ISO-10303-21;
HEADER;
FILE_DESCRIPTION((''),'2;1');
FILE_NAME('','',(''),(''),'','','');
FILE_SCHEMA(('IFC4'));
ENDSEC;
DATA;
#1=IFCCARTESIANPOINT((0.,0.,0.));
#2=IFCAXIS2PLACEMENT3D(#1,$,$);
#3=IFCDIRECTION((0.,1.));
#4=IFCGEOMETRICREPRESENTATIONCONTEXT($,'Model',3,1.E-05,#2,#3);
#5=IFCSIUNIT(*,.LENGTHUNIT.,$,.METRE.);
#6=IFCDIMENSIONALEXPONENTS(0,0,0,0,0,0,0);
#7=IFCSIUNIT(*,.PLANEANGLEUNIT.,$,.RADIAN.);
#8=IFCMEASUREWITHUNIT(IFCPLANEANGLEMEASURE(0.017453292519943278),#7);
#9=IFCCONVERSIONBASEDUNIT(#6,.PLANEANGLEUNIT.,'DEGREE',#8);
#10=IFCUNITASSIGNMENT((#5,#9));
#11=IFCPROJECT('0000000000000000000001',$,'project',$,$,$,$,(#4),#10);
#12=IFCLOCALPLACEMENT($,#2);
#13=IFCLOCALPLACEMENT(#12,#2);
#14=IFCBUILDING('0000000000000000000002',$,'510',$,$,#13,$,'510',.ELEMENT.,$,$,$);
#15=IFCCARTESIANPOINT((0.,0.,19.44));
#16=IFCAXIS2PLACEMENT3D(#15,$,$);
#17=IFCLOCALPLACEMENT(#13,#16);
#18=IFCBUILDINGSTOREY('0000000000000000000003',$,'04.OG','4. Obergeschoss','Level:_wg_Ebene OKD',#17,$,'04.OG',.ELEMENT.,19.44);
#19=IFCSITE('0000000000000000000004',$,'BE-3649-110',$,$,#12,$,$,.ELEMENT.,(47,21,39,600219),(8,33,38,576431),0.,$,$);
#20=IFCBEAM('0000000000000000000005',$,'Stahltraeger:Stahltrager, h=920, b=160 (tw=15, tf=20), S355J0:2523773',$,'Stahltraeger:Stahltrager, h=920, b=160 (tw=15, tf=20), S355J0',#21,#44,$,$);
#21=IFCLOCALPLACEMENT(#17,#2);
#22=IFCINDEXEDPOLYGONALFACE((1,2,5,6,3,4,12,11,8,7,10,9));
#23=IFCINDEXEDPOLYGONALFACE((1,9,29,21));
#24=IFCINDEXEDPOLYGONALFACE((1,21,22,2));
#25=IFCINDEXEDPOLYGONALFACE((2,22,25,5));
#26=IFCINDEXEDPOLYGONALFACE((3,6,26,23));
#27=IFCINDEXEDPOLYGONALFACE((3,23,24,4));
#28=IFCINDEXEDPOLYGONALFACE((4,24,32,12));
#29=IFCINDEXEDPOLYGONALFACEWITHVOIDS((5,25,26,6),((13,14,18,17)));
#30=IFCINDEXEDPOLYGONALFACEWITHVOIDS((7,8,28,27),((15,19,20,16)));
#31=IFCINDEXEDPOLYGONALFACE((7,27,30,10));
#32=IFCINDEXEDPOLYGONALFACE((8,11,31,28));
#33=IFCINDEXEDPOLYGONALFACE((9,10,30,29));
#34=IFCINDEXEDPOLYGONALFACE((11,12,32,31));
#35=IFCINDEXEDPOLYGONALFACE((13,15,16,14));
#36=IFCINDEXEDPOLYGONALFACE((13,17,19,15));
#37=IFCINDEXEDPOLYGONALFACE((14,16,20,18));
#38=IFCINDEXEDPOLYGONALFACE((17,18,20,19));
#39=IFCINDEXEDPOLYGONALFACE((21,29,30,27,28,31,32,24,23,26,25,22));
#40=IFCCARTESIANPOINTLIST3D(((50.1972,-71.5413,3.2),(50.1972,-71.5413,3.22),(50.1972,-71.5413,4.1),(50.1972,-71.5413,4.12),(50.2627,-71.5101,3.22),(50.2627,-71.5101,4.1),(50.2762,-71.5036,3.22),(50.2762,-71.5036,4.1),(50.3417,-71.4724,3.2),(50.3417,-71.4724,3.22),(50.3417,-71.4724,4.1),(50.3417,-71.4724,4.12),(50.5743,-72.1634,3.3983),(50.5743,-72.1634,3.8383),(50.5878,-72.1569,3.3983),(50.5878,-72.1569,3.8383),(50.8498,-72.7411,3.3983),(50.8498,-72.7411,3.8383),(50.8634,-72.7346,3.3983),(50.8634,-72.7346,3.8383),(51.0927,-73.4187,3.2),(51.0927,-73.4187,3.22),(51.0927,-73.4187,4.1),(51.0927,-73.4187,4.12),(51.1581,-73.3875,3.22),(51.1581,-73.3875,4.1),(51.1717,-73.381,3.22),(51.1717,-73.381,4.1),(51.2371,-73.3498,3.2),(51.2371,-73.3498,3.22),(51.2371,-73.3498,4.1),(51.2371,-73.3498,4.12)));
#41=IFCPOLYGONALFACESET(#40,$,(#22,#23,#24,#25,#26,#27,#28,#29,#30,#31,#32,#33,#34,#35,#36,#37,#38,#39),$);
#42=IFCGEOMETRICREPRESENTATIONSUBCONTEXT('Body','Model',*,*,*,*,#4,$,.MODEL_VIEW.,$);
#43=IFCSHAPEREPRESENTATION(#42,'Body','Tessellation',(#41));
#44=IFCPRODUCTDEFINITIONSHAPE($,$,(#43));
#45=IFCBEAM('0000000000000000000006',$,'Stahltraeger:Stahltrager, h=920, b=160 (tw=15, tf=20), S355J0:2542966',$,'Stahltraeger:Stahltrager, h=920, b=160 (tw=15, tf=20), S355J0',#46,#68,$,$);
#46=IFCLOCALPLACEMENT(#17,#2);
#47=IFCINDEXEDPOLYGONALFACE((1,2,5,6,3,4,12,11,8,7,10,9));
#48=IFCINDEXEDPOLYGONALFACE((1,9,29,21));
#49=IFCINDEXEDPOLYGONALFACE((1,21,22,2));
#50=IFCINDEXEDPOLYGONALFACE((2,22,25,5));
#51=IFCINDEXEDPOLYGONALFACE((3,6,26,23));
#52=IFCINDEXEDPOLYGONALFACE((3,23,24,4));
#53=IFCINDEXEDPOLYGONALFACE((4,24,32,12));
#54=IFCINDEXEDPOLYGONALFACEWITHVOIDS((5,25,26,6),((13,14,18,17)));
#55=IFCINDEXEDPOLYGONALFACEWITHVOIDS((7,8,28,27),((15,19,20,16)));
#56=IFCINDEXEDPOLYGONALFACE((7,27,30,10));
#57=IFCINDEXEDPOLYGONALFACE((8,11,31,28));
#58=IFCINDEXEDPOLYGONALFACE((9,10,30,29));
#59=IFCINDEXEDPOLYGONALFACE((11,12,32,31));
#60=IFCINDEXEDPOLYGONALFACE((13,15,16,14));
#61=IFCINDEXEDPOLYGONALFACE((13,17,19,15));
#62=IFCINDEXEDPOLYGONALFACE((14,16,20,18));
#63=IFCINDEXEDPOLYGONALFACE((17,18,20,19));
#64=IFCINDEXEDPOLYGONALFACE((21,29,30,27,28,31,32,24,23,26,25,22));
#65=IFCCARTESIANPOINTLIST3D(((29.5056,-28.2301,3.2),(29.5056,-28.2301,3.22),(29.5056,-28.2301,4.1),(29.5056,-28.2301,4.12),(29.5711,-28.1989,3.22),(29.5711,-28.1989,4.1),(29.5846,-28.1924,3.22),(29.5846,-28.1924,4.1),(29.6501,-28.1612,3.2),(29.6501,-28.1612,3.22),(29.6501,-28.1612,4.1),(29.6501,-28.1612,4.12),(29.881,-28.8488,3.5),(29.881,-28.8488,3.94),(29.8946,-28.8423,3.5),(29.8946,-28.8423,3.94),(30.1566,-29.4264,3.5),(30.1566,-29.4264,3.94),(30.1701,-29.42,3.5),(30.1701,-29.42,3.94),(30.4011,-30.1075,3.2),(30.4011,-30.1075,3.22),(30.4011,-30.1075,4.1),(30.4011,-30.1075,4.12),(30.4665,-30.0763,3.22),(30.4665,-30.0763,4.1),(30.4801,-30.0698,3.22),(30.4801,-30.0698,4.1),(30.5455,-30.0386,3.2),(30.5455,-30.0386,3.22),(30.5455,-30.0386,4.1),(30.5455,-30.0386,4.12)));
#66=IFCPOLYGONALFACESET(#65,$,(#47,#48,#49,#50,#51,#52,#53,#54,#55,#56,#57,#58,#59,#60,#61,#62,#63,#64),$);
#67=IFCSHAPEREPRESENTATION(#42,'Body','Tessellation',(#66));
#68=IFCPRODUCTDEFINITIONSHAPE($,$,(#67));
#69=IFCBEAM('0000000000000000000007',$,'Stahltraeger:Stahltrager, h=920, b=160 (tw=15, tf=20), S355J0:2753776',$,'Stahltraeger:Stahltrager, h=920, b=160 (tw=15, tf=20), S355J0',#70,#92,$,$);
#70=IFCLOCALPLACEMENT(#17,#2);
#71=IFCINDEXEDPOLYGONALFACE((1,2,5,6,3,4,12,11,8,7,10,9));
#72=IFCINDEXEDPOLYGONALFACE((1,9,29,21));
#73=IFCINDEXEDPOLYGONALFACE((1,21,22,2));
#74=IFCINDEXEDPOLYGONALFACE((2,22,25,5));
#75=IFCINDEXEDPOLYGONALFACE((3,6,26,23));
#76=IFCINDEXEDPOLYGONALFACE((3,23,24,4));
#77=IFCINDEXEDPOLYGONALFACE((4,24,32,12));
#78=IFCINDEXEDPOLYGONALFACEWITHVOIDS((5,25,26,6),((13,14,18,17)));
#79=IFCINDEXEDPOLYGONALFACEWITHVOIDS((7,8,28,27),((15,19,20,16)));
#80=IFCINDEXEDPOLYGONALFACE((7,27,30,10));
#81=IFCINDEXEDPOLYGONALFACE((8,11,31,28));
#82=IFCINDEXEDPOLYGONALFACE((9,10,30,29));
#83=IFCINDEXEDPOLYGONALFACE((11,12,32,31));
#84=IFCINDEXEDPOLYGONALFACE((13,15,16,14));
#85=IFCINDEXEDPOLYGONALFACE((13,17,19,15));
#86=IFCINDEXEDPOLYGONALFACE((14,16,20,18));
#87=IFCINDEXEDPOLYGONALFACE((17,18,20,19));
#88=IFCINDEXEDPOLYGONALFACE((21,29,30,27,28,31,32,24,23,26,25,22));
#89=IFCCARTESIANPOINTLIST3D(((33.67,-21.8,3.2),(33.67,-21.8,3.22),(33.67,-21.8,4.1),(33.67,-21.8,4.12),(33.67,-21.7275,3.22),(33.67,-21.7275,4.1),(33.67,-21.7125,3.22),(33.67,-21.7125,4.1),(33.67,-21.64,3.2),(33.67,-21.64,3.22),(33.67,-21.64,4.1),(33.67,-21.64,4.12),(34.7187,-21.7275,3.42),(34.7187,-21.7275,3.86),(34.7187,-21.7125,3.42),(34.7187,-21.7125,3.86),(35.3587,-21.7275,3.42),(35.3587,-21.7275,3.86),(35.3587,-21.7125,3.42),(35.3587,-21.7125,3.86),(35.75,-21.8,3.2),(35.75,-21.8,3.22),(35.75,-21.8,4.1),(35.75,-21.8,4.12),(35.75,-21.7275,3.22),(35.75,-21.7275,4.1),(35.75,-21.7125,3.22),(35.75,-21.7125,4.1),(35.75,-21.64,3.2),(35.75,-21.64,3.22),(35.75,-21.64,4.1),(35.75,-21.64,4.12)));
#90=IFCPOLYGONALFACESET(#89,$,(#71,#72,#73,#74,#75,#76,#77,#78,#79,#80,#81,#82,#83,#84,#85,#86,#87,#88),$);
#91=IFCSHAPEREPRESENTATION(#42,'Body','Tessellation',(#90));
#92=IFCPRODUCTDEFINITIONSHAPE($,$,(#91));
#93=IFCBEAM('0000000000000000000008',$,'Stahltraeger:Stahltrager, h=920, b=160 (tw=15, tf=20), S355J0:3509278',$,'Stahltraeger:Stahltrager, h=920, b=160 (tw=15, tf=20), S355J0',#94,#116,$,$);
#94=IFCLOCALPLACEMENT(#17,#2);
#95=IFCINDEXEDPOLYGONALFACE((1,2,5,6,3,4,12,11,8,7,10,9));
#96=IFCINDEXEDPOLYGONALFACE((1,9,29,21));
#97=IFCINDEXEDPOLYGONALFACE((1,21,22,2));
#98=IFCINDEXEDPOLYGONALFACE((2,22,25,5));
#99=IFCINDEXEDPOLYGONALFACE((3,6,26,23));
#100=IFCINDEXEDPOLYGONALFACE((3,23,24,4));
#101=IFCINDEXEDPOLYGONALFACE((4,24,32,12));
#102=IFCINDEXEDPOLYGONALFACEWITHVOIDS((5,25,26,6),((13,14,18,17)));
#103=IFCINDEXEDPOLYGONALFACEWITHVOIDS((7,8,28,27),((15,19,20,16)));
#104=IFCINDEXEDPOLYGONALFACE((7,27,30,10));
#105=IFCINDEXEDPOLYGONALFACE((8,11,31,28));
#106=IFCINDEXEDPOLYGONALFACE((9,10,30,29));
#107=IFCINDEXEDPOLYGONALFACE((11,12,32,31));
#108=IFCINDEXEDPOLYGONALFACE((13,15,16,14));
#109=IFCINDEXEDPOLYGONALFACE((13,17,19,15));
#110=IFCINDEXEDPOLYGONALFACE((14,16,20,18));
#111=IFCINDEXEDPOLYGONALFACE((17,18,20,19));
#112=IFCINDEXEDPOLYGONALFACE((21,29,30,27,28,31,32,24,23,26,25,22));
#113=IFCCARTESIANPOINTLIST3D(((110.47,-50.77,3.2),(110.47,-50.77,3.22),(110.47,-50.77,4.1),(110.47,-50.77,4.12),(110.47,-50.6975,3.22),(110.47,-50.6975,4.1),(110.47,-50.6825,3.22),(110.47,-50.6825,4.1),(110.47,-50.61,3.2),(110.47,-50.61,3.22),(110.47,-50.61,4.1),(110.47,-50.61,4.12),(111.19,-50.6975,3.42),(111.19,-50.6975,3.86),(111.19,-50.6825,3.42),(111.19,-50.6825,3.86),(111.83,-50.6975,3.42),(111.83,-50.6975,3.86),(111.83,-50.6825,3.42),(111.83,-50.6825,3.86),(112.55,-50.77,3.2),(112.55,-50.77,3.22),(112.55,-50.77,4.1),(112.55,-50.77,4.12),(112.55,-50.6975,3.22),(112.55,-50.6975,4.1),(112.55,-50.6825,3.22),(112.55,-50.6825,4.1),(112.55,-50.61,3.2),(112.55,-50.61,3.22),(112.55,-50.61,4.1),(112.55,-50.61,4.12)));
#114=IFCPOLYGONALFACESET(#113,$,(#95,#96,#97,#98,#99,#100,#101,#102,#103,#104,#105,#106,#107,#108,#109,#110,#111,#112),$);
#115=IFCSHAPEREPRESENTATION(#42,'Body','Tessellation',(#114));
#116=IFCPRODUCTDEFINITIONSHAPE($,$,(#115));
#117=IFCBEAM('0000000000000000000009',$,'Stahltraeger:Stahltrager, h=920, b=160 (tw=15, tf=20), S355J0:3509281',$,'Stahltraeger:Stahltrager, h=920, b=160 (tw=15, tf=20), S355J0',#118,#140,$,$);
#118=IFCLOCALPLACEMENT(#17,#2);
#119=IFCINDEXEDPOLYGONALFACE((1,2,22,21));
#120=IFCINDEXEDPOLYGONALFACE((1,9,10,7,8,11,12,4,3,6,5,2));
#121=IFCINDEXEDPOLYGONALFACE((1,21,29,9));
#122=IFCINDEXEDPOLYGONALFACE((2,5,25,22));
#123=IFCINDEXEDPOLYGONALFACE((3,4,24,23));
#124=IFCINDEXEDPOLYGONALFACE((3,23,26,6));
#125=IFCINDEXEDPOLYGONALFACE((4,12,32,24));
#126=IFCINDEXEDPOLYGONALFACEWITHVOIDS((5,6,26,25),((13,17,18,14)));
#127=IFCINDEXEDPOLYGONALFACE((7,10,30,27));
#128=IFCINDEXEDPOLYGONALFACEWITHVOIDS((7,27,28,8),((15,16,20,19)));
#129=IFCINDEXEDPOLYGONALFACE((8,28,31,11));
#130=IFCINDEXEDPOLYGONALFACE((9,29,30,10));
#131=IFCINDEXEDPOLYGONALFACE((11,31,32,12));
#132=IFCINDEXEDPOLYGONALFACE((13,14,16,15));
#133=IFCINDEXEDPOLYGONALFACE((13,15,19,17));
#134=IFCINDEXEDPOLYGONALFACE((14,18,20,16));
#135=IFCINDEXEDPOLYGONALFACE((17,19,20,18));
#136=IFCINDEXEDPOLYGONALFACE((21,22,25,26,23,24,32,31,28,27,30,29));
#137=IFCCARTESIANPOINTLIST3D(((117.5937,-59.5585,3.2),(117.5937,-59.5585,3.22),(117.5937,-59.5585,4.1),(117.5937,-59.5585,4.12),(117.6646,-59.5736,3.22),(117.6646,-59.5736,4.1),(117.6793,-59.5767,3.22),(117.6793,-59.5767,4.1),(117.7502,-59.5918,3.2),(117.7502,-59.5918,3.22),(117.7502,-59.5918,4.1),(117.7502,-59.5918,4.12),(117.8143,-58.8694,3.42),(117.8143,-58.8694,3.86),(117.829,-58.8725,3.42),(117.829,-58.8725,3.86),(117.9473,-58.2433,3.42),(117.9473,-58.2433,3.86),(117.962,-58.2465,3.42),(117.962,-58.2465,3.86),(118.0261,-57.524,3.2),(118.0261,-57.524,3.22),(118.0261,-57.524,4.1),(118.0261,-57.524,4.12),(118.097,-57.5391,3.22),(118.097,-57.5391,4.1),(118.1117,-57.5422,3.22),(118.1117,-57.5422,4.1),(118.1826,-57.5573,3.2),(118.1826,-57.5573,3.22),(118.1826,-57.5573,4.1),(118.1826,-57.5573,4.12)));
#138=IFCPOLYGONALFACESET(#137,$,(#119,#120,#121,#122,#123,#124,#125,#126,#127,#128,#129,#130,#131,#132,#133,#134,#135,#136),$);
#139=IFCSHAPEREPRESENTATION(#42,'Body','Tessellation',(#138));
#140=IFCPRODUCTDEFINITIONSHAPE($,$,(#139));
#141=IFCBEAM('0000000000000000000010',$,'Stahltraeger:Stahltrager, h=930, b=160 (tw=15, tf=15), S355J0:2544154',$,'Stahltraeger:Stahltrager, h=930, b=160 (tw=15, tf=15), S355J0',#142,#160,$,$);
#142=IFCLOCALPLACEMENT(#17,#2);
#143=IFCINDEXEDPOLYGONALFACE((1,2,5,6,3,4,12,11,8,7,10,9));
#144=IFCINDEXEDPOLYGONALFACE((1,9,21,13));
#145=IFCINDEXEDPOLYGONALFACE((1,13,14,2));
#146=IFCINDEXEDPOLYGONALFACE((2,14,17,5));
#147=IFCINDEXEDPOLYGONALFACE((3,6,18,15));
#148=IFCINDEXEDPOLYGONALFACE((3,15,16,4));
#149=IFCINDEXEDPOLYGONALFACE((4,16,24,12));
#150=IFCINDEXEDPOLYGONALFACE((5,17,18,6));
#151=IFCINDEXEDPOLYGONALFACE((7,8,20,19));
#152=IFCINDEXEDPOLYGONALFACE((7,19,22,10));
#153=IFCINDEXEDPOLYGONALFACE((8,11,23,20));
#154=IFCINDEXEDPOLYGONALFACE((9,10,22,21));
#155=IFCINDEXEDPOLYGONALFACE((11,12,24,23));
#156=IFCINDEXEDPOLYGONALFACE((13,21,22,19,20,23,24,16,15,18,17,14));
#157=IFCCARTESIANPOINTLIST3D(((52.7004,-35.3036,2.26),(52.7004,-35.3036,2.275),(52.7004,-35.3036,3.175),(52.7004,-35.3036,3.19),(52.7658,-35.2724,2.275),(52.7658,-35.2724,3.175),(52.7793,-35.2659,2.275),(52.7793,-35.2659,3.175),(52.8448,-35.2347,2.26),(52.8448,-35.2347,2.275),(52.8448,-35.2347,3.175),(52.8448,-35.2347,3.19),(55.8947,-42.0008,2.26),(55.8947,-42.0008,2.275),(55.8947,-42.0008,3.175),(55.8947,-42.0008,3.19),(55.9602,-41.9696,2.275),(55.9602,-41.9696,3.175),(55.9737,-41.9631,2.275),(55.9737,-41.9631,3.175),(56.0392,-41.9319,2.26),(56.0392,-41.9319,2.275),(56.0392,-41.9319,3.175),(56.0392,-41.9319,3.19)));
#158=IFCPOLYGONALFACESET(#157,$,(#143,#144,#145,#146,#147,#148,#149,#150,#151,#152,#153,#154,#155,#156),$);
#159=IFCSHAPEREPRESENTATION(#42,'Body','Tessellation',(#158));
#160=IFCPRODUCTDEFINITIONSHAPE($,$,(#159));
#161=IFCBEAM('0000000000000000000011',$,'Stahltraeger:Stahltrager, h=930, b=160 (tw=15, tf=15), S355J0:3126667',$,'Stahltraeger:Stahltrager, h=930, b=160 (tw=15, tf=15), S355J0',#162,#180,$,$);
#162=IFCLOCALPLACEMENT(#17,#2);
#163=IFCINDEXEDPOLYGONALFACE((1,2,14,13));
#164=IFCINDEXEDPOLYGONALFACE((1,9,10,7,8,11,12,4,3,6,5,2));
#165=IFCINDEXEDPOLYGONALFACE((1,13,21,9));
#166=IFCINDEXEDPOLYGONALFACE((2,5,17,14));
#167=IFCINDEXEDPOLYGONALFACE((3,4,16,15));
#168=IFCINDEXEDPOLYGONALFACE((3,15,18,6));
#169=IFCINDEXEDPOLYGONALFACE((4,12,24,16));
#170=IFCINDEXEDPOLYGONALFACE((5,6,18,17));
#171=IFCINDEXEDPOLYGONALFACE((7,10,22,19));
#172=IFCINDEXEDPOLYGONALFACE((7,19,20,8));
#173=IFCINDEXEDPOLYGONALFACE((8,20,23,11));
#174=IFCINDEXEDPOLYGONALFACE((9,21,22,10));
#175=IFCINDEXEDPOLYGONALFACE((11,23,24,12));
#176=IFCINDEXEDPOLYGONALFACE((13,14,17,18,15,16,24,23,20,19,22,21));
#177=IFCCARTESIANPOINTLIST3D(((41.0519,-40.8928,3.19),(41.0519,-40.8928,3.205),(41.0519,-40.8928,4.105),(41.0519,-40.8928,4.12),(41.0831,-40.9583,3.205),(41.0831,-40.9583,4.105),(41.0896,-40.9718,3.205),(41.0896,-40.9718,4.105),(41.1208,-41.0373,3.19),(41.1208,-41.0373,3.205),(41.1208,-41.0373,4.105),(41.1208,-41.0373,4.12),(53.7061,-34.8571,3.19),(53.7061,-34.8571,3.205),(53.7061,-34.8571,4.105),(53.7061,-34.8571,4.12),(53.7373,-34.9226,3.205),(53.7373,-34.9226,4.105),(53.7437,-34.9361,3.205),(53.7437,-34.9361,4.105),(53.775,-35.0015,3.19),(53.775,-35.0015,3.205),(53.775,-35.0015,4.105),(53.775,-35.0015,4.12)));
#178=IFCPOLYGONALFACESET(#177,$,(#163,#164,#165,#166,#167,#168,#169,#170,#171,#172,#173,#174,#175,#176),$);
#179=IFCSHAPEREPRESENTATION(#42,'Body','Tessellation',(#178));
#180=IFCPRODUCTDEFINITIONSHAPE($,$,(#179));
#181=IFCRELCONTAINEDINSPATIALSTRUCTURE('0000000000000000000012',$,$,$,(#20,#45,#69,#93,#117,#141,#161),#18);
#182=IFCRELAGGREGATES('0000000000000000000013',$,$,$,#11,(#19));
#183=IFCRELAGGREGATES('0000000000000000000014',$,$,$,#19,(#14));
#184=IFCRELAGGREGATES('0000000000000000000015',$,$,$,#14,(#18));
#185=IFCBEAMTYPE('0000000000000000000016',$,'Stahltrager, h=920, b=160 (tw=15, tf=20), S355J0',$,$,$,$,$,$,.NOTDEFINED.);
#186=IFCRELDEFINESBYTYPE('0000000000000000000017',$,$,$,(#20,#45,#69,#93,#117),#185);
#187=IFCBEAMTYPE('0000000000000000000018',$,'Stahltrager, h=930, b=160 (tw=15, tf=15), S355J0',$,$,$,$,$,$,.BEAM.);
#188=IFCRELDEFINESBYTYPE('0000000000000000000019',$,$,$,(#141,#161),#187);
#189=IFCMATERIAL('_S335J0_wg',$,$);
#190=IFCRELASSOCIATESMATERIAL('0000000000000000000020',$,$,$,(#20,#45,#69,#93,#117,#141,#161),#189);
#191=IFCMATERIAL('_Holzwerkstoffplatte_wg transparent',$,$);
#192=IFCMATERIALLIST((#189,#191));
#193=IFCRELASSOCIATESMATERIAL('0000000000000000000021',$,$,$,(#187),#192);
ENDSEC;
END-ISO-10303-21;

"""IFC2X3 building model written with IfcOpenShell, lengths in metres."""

from ifc_helpers import new_model, entity, si_unit, converted_unit, direction, frame, frame_2d, origin, place, context, subcontext, project, spatial, rectangle, i_section, extrude, boolean, material, material_list, type_object, element, save


model = new_model("IFC2X3")

# Units and contexts
model_context = context("Model", 3, precision=1e-05, world=origin(), true_north=direction((0.0, 1.0)))
body_context = subcontext(model_context, "Body", "Model", "MODEL_VIEW")
ifc_project = project(units=[si_unit("LENGTHUNIT", "METRE"), converted_unit("PLANEANGLEUNIT", "DEGREE", entity("IfcPlaneAngleMeasure", 0.017453292519943278), si_unit("PLANEANGLEUNIT", "RADIAN"), dimensions=[0, 0, 0, 0, 0, 0, 0])], contexts=[model_context])

# Site, building, storey
site_placement = place(None, origin())
site = spatial("IfcSite", under=ifc_project, at=site_placement, Name="BE-3649-110", CompositionType="ELEMENT", RefLatitude=(47, 21, 39, 600219), RefLongitude=(8, 33, 38, 576431), RefElevation=0.0)
building_placement = place(site_placement, origin())
building = spatial("IfcBuilding", under=site, at=building_placement, Name="510", LongName="510", CompositionType="ELEMENT")
storey_placement = place(building_placement, frame((0.0, 0.0, 19.44)))
storey = spatial("IfcBuildingStorey", under=building, at=storey_placement, Name="04.OG", Description="4. Obergeschoss", ObjectType="Level:_wg_Ebene OKD", LongName="04.OG", CompositionType="ELEMENT", Elevation=19.44)

# Beams
ifc_material_1 = material(Name="_S335J0_wg")
beam_type_1 = type_object("IfcBeamType", Name="Stahltrager, h=920, b=160 (tw=15, tf=20), S355J0", PredefinedType="NOTDEFINED")
beam_1_placement = place(storey_placement, frame((50.2695, -71.5068, 4.12), z_axis=(0.0, 0.0, 1.0), x_axis=(0.430511, -0.902585, 0.0)))
element("IfcBeam", 1, at=beam_1_placement, inside=storey, type_object=beam_type_1, material=ifc_material_1, Name="Stahltraeger:Stahltrager, h=920, b=160 (tw=15, tf=20), S355J0:2523773", ObjectType="Stahltraeger:Stahltrager, h=920, b=160 (tw=15, tf=20), S355J0", context=body_context, shape_type="SweptSolid", body=[
    boolean("DIFFERENCE", extrude(i_section(OverallWidth=0.16, OverallDepth=0.92, WebThickness=0.015, FlangeThickness=0.02, at=frame_2d((0.0, 0.0), x_axis=(0.0, 1.0))), frame((0.0, 0.0, -0.46), z_axis=(1.0, 0.0, 0.0), x_axis=(0.0, 0.0, -1.0)), (0.0, 0.0, 1.0), 2.08), extrude(rectangle(XDim=0.44, YDim=0.64, at=frame_2d((0.0, 0.0), x_axis=(0.0, 1.0))), frame((1.0438, 0.0075, -0.5017), z_axis=(0.0, -1.0, 0.0), x_axis=(-1.0, 0.0, 0.0)), (0.0, 0.0, 1.0), 0.015)),
])
beam_2_placement = place(storey_placement, frame((30.4733, -30.073, 4.12), z_axis=(0.0, 0.0, 1.0), x_axis=(-0.430511, 0.902585, 0.0)))
element("IfcBeam", 2, at=beam_2_placement, inside=storey, type_object=beam_type_1, material=ifc_material_1, Name="Stahltraeger:Stahltrager, h=920, b=160 (tw=15, tf=20), S355J0:2542966", ObjectType="Stahltraeger:Stahltrager, h=920, b=160 (tw=15, tf=20), S355J0", context=body_context, shape_type="SweptSolid", body=[
    boolean("DIFFERENCE", extrude(i_section(OverallWidth=0.16, OverallDepth=0.92, WebThickness=0.015, FlangeThickness=0.02, at=frame_2d((0.0, 0.0), x_axis=(0.0, 1.0))), frame((0.0, 0.0, -0.46), z_axis=(1.0, 0.0, 0.0), x_axis=(0.0, 0.0, -1.0)), (0.0, 0.0, 1.0), 2.08), extrude(rectangle(XDim=0.44, YDim=0.64, at=frame_2d((0.0, 0.0), x_axis=(0.0, 1.0))), frame((1.04, 0.0075, -0.4), z_axis=(0.0, -1.0, 0.0), x_axis=(-1.0, 0.0, 0.0)), (0.0, 0.0, 1.0), 0.015)),
])
beam_3_placement = place(storey_placement, frame((33.67, -21.72, 4.12)))
element("IfcBeam", 3, at=beam_3_placement, inside=storey, type_object=beam_type_1, material=ifc_material_1, Name="Stahltraeger:Stahltrager, h=920, b=160 (tw=15, tf=20), S355J0:2753776", ObjectType="Stahltraeger:Stahltrager, h=920, b=160 (tw=15, tf=20), S355J0", context=body_context, shape_type="SweptSolid", body=[
    boolean("DIFFERENCE", extrude(i_section(OverallWidth=0.16, OverallDepth=0.92, WebThickness=0.015, FlangeThickness=0.02, at=frame_2d((0.0, 0.0), x_axis=(0.0, 1.0))), frame((0.0, 0.0, -0.46), z_axis=(1.0, 0.0, 0.0), x_axis=(0.0, 0.0, -1.0)), (0.0, 0.0, 1.0), 2.08), extrude(rectangle(XDim=0.44, YDim=0.64, at=frame_2d((0.0, 0.0), x_axis=(0.0, 1.0))), frame((1.3687, 0.0075, -0.48), z_axis=(0.0, -1.0, 0.0), x_axis=(-1.0, 0.0, 0.0)), (0.0, 0.0, 1.0), 0.015)),
])
beam_4_placement = place(storey_placement, frame((110.47, -50.69, 4.12)))
element("IfcBeam", 4, at=beam_4_placement, inside=storey, type_object=beam_type_1, material=ifc_material_1, Name="Stahltraeger:Stahltrager, h=920, b=160 (tw=15, tf=20), S355J0:3509278", ObjectType="Stahltraeger:Stahltrager, h=920, b=160 (tw=15, tf=20), S355J0", context=body_context, shape_type="SweptSolid", body=[
    boolean("DIFFERENCE", extrude(i_section(OverallWidth=0.16, OverallDepth=0.92, WebThickness=0.015, FlangeThickness=0.02, at=frame_2d((0.0, 0.0), x_axis=(0.0, 1.0))), frame((0.0, 0.0, -0.46), z_axis=(1.0, 0.0, 0.0), x_axis=(0.0, 0.0, -1.0)), (0.0, 0.0, 1.0), 2.08), extrude(rectangle(XDim=0.44, YDim=0.64, at=frame_2d((0.0, 0.0), x_axis=(0.0, 1.0))), frame((1.04, 0.0075, -0.48), z_axis=(0.0, -1.0, 0.0), x_axis=(-1.0, 0.0, 0.0)), (0.0, 0.0, 1.0), 0.015)),
])
beam_5_placement = place(storey_placement, frame((118.1044, -57.5406, 4.12), z_axis=(0.0, 0.0, 1.0), x_axis=(-0.207912, -0.978148, 0.0)))
element("IfcBeam", 5, at=beam_5_placement, inside=storey, type_object=beam_type_1, material=ifc_material_1, Name="Stahltraeger:Stahltrager, h=920, b=160 (tw=15, tf=20), S355J0:3509281", ObjectType="Stahltraeger:Stahltrager, h=920, b=160 (tw=15, tf=20), S355J0", context=body_context, shape_type="SweptSolid", body=[
    boolean("DIFFERENCE", extrude(i_section(OverallWidth=0.16, OverallDepth=0.92, WebThickness=0.015, FlangeThickness=0.02, at=frame_2d((0.0, 0.0), x_axis=(0.0, 1.0))), frame((0.0, 0.0, -0.46), z_axis=(1.0, 0.0, 0.0), x_axis=(0.0, 0.0, -1.0)), (0.0, 0.0, 1.0), 2.08), extrude(rectangle(XDim=0.44, YDim=0.64, at=frame_2d((0.0, 0.0), x_axis=(0.0, 1.0))), frame((1.04, 0.0075, -0.48), z_axis=(0.0, -1.0, 0.0), x_axis=(-1.0, 0.0, 0.0)), (0.0, 0.0, 1.0), 0.015)),
])
ifc_material_2 = material(Name="_Holzwerkstoffplatte_wg transparent")
ifc_material_list = material_list([ifc_material_1, ifc_material_2])
beam_type_2 = type_object("IfcBeamType", Name="Stahltrager, h=930, b=160 (tw=15, tf=15), S355J0", PredefinedType="BEAM", material=ifc_material_list)
beam_6_placement = place(storey_placement, frame((52.7726, -35.2691, 3.19), z_axis=(0.0, 0.0, 1.0), x_axis=(0.430511, -0.902585, 0.0)))
element("IfcBeam", 6, at=beam_6_placement, inside=storey, type_object=beam_type_2, material=ifc_material_1, Name="Stahltraeger:Stahltrager, h=930, b=160 (tw=15, tf=15), S355J0:2544154", ObjectType="Stahltraeger:Stahltrager, h=930, b=160 (tw=15, tf=15), S355J0", context=body_context, shape_type="SweptSolid", body=[
    extrude(i_section(OverallWidth=0.16, OverallDepth=0.93, WebThickness=0.015, FlangeThickness=0.015, at=frame_2d((0.0, 0.0), x_axis=(0.0, 1.0))), frame((0.0, 0.0, -0.465), z_axis=(1.0, 0.0, 0.0), x_axis=(0.0, 0.0, -1.0)), (0.0, 0.0, 1.0), 7.42),
])
beam_7_placement = place(storey_placement, frame((41.0863, -40.9651, 4.12), z_axis=(0.0, 0.0, 1.0), x_axis=(0.902585, 0.430511, 0.0)))
element("IfcBeam", 7, at=beam_7_placement, inside=storey, type_object=beam_type_2, material=ifc_material_1, Name="Stahltraeger:Stahltrager, h=930, b=160 (tw=15, tf=15), S355J0:3126667", ObjectType="Stahltraeger:Stahltrager, h=930, b=160 (tw=15, tf=15), S355J0", context=body_context, shape_type="SweptSolid", body=[
    extrude(i_section(OverallWidth=0.16, OverallDepth=0.93, WebThickness=0.015, FlangeThickness=0.015, at=frame_2d((0.0, 0.0), x_axis=(0.0, 1.0))), frame((0.0, 0.0, -0.465), z_axis=(1.0, 0.0, 0.0), x_axis=(0.0, 0.0, -1.0)), (0.0, 0.0, 1.0), 14.0199),
])

save(model, "model.ifc")
